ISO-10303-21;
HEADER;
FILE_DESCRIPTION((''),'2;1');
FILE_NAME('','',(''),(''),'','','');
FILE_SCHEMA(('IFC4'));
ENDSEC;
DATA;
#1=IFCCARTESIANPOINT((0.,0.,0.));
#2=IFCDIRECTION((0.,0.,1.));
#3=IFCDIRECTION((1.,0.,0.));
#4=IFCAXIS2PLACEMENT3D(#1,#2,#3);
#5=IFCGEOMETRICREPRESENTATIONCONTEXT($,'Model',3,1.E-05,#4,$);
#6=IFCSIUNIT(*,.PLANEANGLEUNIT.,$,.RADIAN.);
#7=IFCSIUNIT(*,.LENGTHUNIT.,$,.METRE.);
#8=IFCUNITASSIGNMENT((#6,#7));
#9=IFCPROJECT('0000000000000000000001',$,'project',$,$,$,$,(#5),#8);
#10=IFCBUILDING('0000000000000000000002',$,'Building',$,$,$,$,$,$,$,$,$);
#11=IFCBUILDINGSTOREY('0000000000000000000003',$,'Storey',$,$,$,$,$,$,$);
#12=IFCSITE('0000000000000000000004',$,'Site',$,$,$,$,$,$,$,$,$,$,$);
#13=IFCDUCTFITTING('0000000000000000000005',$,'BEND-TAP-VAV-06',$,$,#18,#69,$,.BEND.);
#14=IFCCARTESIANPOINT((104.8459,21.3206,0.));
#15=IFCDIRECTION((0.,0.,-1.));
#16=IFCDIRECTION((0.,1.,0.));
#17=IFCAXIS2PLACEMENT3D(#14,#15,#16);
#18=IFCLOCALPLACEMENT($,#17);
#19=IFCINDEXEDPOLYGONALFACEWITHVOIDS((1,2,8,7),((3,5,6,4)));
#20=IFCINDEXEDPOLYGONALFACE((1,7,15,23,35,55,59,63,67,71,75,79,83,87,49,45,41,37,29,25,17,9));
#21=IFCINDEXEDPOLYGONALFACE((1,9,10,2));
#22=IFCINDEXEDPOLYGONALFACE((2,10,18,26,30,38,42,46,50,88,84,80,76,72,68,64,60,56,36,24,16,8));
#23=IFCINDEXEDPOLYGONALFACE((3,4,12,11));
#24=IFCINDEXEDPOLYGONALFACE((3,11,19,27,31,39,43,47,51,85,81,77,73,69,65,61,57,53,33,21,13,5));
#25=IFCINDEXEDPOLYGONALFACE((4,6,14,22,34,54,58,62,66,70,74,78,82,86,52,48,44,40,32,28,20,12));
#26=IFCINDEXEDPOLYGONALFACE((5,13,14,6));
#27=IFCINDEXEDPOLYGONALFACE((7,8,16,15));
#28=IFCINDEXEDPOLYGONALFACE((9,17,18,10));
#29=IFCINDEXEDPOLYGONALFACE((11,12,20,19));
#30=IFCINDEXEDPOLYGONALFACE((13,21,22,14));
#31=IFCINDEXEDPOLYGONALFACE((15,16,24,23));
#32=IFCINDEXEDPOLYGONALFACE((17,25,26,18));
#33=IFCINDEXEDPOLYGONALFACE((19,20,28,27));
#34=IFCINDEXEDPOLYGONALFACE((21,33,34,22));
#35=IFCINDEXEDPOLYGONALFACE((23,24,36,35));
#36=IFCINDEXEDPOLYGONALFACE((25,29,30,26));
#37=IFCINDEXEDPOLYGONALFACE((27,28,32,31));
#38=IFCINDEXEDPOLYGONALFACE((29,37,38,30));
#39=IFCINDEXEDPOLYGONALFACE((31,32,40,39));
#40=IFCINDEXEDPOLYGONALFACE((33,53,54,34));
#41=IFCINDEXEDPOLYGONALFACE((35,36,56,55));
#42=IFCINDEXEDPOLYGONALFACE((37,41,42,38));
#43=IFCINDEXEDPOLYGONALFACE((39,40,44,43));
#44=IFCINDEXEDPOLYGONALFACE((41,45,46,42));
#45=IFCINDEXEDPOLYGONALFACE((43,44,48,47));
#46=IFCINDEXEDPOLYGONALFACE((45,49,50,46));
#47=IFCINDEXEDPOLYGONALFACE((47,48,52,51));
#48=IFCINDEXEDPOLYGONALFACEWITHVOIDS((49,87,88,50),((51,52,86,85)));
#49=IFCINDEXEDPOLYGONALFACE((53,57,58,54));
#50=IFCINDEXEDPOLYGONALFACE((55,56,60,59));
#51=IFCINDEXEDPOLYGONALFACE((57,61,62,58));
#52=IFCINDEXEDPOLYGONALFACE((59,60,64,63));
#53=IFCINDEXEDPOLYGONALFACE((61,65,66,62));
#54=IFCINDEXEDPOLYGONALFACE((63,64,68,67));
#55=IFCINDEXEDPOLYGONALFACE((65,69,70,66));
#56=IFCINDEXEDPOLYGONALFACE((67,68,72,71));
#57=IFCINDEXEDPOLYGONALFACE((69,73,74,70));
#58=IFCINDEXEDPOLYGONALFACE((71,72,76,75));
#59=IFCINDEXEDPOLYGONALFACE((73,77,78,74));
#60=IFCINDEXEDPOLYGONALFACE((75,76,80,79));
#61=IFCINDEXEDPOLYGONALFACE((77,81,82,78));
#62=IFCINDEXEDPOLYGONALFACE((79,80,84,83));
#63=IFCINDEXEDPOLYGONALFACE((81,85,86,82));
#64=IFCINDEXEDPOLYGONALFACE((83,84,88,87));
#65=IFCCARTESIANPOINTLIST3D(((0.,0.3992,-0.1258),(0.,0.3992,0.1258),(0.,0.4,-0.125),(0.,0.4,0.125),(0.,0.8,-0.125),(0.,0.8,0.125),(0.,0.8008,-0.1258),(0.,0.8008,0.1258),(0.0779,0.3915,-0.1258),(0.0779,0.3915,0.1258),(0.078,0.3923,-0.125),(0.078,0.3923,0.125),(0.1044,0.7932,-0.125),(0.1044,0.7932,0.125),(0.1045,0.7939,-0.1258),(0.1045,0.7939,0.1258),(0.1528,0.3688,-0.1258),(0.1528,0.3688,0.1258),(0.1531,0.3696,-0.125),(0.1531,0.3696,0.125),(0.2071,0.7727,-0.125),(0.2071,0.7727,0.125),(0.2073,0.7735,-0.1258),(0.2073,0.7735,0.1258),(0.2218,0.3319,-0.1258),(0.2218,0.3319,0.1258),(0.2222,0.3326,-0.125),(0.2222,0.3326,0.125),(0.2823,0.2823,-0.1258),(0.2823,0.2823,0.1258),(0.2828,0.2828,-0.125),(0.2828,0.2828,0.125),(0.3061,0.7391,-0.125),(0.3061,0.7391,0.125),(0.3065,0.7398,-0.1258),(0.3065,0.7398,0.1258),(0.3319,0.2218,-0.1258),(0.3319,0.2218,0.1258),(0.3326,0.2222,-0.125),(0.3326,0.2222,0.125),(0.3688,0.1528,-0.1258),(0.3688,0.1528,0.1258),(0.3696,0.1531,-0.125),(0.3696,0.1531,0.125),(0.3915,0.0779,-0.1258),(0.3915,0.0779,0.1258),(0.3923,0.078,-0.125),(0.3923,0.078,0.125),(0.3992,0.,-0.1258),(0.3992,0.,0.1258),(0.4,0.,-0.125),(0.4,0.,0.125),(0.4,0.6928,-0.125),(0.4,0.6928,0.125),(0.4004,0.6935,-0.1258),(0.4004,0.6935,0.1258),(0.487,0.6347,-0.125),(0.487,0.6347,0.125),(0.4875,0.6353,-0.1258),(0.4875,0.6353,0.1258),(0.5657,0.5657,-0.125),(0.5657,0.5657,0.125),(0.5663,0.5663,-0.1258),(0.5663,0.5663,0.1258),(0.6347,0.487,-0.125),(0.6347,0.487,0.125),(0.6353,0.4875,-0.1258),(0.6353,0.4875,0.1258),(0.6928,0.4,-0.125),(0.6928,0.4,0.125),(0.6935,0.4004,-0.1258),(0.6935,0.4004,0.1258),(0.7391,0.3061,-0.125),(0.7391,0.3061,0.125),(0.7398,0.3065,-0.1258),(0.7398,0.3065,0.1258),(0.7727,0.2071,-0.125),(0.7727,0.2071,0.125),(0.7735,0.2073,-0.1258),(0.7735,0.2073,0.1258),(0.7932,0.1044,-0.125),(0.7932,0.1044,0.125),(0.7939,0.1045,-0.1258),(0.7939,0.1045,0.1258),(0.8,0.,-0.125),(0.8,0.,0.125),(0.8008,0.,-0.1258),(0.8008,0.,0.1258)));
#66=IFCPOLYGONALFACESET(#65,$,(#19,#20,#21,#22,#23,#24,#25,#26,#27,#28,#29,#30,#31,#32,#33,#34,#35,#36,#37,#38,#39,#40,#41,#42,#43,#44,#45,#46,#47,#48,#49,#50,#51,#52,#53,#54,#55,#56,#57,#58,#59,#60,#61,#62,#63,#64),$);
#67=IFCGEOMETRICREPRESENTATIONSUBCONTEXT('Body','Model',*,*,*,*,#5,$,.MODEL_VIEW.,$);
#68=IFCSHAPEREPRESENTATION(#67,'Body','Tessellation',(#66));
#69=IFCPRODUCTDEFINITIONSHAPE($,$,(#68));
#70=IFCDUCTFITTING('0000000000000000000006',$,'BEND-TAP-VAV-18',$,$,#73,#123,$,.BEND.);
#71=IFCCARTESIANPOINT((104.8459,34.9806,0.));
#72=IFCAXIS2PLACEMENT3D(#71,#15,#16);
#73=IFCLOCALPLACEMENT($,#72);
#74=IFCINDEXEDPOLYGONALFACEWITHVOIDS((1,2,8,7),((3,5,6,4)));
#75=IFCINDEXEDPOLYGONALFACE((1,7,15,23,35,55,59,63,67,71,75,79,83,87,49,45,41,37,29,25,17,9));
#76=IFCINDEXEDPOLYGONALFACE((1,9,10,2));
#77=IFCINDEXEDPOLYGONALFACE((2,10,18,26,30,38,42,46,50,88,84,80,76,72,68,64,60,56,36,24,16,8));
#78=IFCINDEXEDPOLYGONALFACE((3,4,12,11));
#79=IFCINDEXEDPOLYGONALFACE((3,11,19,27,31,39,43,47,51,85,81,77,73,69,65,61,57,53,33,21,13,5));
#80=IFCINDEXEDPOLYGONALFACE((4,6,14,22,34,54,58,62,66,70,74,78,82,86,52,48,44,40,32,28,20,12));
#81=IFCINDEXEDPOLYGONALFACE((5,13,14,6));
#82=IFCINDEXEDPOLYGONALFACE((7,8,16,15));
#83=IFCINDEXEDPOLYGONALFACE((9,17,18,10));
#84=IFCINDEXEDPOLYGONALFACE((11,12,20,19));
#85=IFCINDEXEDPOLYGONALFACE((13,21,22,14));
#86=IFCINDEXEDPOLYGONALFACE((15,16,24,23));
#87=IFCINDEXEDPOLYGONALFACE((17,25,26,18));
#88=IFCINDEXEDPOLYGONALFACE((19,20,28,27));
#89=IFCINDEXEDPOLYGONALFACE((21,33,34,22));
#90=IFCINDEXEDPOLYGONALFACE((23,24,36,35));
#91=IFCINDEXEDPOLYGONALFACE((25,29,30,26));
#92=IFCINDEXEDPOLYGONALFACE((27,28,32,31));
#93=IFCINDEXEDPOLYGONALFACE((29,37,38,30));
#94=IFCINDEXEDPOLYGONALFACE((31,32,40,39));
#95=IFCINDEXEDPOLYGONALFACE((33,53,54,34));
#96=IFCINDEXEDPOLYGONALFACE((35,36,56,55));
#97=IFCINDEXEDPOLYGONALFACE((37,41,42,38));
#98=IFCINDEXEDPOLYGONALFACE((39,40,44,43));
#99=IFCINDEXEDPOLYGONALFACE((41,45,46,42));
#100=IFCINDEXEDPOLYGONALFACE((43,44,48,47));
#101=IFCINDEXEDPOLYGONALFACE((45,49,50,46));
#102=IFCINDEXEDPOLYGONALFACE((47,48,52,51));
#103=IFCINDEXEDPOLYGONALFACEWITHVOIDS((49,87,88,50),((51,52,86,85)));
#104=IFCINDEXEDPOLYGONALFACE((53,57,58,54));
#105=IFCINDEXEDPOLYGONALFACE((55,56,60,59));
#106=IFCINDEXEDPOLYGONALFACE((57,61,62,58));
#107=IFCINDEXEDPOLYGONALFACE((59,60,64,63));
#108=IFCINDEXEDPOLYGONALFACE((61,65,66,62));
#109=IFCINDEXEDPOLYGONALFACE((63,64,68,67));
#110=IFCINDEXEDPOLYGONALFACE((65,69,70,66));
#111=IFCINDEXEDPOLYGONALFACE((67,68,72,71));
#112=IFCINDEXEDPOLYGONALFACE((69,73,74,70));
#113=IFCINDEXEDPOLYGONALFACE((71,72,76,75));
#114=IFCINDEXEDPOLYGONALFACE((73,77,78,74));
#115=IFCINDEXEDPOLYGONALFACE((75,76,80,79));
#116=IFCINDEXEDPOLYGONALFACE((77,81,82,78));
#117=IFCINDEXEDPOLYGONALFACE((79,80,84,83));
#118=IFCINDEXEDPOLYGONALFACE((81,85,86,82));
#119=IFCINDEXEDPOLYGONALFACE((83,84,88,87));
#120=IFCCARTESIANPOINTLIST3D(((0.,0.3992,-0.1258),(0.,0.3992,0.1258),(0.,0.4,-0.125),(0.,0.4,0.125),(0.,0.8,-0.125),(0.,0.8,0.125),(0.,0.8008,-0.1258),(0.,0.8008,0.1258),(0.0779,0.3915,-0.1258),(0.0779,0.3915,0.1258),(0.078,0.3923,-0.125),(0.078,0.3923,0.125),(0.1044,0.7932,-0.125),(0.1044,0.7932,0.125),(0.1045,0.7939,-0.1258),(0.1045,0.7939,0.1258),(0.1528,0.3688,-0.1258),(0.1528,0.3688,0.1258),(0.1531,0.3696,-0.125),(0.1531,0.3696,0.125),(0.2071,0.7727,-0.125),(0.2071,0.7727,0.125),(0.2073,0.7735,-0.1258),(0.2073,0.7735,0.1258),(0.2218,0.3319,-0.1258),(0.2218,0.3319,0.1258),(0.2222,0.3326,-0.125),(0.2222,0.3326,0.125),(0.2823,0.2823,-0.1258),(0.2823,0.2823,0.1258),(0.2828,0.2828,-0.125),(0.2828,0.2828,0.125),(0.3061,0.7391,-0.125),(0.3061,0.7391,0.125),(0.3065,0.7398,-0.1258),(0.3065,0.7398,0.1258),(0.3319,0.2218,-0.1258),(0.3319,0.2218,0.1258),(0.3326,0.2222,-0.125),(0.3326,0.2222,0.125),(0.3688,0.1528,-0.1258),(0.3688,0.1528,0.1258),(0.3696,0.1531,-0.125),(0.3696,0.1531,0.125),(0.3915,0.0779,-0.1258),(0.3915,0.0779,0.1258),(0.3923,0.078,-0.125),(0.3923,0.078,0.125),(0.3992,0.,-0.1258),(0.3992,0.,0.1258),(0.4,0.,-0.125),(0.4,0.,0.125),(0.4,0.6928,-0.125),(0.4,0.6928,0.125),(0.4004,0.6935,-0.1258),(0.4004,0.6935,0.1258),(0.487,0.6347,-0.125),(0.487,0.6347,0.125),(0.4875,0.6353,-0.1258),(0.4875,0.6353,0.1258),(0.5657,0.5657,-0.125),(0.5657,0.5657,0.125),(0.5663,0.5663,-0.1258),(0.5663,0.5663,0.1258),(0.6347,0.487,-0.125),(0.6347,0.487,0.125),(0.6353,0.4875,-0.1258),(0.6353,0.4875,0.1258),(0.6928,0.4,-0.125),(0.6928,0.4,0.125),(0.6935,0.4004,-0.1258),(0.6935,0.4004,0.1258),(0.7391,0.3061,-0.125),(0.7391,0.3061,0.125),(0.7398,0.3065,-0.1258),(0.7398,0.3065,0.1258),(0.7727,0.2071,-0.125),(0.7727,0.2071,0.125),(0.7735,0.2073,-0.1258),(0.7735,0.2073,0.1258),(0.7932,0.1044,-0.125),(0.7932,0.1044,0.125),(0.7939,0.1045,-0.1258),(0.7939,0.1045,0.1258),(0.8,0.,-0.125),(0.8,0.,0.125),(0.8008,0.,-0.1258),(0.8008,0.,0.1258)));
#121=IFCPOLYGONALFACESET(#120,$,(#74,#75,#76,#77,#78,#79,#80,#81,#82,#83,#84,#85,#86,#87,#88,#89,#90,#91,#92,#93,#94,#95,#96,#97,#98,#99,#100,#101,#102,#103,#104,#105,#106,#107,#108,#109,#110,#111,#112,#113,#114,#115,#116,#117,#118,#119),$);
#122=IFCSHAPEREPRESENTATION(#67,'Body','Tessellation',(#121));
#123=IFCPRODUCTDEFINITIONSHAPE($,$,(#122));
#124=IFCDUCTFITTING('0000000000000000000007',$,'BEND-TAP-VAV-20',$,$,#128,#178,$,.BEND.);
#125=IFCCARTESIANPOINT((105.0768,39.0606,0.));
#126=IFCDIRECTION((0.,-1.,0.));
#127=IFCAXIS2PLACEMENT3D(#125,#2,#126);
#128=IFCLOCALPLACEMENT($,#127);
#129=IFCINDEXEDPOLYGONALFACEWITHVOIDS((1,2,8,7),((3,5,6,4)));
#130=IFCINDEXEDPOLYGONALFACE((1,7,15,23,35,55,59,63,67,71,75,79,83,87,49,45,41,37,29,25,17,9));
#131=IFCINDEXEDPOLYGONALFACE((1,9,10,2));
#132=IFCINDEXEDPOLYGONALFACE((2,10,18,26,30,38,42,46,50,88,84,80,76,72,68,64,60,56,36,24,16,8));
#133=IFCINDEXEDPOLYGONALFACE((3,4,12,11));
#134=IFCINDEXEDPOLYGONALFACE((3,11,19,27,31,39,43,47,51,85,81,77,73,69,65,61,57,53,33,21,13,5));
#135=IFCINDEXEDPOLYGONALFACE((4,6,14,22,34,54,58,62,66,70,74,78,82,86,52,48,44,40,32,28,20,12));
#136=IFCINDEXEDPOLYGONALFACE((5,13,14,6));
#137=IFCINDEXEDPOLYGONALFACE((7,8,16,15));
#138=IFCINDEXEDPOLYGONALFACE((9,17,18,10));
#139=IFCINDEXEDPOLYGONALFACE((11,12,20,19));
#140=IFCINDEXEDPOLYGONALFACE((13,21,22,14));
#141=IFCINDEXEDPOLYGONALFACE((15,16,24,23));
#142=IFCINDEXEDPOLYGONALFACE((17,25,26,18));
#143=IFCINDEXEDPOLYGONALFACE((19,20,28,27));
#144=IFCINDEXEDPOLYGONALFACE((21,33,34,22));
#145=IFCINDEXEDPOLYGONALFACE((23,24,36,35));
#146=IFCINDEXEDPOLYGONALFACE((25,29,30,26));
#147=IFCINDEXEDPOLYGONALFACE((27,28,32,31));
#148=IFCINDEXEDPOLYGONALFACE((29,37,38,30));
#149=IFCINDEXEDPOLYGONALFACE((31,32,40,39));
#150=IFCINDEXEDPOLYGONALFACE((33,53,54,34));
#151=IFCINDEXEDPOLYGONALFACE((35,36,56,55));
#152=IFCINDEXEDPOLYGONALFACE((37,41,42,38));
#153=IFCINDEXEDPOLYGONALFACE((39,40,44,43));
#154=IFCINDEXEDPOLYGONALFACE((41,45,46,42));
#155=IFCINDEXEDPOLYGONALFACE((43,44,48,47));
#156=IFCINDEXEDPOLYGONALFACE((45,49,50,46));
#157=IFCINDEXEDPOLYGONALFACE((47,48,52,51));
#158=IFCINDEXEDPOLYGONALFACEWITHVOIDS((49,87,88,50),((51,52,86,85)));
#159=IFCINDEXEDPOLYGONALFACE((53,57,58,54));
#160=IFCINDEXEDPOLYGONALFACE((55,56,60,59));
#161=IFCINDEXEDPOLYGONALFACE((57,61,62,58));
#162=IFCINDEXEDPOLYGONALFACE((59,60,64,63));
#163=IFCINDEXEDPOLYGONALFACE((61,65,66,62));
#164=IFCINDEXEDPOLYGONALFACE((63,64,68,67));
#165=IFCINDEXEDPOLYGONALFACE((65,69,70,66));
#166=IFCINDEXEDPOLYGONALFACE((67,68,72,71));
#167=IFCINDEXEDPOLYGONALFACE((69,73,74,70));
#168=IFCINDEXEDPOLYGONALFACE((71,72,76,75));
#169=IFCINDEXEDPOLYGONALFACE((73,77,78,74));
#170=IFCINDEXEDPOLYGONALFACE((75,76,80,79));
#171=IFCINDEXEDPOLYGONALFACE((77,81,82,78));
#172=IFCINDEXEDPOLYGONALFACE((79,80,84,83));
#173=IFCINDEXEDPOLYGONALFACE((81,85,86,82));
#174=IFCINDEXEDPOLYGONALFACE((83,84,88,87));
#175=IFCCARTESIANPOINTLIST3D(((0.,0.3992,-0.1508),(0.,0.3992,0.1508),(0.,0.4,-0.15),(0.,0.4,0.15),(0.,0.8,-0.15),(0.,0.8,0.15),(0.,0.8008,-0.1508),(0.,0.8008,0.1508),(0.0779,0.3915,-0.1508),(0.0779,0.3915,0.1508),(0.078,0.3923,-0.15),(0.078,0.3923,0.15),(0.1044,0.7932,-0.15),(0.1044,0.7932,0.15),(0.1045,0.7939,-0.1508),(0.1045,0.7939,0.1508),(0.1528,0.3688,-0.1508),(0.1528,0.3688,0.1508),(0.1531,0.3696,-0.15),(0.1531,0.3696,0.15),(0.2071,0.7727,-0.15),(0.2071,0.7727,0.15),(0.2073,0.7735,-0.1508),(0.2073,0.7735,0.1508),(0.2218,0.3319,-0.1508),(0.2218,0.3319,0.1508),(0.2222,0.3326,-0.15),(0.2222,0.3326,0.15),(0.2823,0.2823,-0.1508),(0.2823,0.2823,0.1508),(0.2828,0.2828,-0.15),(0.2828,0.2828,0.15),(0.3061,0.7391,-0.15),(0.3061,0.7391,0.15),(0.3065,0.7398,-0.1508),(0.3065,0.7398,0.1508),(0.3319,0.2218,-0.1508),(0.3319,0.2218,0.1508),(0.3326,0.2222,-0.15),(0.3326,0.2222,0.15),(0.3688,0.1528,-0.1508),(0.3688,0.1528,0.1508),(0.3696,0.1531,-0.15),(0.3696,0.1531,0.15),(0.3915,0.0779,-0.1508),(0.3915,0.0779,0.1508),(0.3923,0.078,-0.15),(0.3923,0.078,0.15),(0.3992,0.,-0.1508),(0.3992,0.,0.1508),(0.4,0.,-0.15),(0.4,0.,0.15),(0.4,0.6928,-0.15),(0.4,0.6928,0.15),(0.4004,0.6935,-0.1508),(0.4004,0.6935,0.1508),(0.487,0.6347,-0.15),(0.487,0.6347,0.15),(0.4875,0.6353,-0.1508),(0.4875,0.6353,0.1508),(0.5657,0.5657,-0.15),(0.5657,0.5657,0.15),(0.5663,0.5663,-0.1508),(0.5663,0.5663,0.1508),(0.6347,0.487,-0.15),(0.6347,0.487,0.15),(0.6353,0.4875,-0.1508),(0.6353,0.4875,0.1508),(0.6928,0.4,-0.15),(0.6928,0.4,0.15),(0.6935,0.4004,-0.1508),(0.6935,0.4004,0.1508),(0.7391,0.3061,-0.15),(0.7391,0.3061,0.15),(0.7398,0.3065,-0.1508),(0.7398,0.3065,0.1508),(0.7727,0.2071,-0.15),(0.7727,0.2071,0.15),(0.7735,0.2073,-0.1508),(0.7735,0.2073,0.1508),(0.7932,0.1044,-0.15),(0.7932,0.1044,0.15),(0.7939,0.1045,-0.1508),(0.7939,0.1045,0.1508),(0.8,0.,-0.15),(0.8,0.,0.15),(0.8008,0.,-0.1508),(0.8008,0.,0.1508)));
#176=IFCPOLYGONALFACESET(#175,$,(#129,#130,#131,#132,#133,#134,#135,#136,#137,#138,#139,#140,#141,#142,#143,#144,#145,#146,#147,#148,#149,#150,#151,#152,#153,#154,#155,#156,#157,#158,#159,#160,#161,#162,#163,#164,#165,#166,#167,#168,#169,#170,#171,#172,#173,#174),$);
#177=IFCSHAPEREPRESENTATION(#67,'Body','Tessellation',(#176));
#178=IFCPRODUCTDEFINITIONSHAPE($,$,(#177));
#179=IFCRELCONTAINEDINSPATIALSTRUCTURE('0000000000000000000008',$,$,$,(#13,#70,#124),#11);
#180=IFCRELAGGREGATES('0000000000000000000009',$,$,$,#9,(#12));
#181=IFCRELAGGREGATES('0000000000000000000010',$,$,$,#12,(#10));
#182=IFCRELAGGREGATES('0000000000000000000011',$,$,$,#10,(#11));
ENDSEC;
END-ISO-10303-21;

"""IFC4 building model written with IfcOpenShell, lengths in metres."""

from ifc_helpers import new_model, entity, si_unit, frame, origin_with_axes, place, context, subcontext, project, spatial, element, save


model = new_model("IFC4")

# Units and contexts
model_context = context("Model", 3, precision=1e-05, world=origin_with_axes())
body_context = subcontext(model_context, "Body", "Model", "MODEL_VIEW")
ifc_project = project(units=[si_unit("PLANEANGLEUNIT", "RADIAN"), si_unit("LENGTHUNIT", "METRE")], contexts=[model_context])

# Site, building, storey
site = spatial("IfcSite", under=ifc_project, Name="Site")
building = spatial("IfcBuilding", under=site, Name="Building")
storey = spatial("IfcBuildingStorey", under=building, Name="Storey")

# Duct fittings
duct_fitting_1_placement = place(None, frame((104.8459, 21.3206, 0.0), z_axis=(0.0, 0.0, -1.0), x_axis=(0.0, 1.0, 0.0)))
cartesian_point_1 = entity("IfcCartesianPoint", [0.0, 0.0, 0.0])
element("IfcDuctFitting", 1, at=duct_fitting_1_placement, inside=storey, Name="BEND-TAP-VAV-06", PredefinedType="BEND", context=body_context, shape_type="SweptSolid", body=[
    entity("IfcRevolvedAreaSolid", entity("IfcRectangleHollowProfileDef", "AREA", None, entity("IfcAxis2Placement2D", entity("IfcCartesianPoint", [0.6, 0.0])), 0.4016, 0.2516, 0.0008), entity("IfcAxis2Placement3D", cartesian_point_1, entity("IfcDirection", [0.0, -1.0, 0.0]), entity("IfcDirection", [1.0, 0.0, 0.0])), entity("IfcAxis1Placement", cartesian_point_1, entity("IfcDirection", [0.0, 1.0, 0.0])), 1.570796),
])
duct_fitting_2_placement = place(None, frame((104.8459, 34.9806, 0.0), z_axis=(0.0, 0.0, -1.0), x_axis=(0.0, 1.0, 0.0)))
cartesian_point_2 = entity("IfcCartesianPoint", [0.0, 0.0, 0.0])
element("IfcDuctFitting", 2, at=duct_fitting_2_placement, inside=storey, Name="BEND-TAP-VAV-18", PredefinedType="BEND", context=body_context, shape_type="SweptSolid", body=[
    entity("IfcRevolvedAreaSolid", entity("IfcRectangleHollowProfileDef", "AREA", None, entity("IfcAxis2Placement2D", entity("IfcCartesianPoint", [0.6, 0.0])), 0.4016, 0.2516, 0.0008), entity("IfcAxis2Placement3D", cartesian_point_2, entity("IfcDirection", [0.0, -1.0, 0.0]), entity("IfcDirection", [1.0, 0.0, 0.0])), entity("IfcAxis1Placement", cartesian_point_2, entity("IfcDirection", [0.0, 1.0, 0.0])), 1.570796),
])
duct_fitting_3_placement = place(None, frame((105.0768, 39.0606, 0.0), z_axis=(0.0, 0.0, 1.0), x_axis=(0.0, -1.0, 0.0)))
cartesian_point_3 = entity("IfcCartesianPoint", [0.0, 0.0, 0.0])
element("IfcDuctFitting", 3, at=duct_fitting_3_placement, inside=storey, Name="BEND-TAP-VAV-20", PredefinedType="BEND", context=body_context, shape_type="SweptSolid", body=[
    entity("IfcRevolvedAreaSolid", entity("IfcRectangleHollowProfileDef", "AREA", None, entity("IfcAxis2Placement2D", entity("IfcCartesianPoint", [0.6, 0.0])), 0.4016, 0.3016, 0.0008), entity("IfcAxis2Placement3D", cartesian_point_3, entity("IfcDirection", [0.0, -1.0, 0.0]), entity("IfcDirection", [1.0, 0.0, 0.0])), entity("IfcAxis1Placement", cartesian_point_3, entity("IfcDirection", [0.0, 1.0, 0.0])), 1.570796),
])

save(model, "model.ifc")
